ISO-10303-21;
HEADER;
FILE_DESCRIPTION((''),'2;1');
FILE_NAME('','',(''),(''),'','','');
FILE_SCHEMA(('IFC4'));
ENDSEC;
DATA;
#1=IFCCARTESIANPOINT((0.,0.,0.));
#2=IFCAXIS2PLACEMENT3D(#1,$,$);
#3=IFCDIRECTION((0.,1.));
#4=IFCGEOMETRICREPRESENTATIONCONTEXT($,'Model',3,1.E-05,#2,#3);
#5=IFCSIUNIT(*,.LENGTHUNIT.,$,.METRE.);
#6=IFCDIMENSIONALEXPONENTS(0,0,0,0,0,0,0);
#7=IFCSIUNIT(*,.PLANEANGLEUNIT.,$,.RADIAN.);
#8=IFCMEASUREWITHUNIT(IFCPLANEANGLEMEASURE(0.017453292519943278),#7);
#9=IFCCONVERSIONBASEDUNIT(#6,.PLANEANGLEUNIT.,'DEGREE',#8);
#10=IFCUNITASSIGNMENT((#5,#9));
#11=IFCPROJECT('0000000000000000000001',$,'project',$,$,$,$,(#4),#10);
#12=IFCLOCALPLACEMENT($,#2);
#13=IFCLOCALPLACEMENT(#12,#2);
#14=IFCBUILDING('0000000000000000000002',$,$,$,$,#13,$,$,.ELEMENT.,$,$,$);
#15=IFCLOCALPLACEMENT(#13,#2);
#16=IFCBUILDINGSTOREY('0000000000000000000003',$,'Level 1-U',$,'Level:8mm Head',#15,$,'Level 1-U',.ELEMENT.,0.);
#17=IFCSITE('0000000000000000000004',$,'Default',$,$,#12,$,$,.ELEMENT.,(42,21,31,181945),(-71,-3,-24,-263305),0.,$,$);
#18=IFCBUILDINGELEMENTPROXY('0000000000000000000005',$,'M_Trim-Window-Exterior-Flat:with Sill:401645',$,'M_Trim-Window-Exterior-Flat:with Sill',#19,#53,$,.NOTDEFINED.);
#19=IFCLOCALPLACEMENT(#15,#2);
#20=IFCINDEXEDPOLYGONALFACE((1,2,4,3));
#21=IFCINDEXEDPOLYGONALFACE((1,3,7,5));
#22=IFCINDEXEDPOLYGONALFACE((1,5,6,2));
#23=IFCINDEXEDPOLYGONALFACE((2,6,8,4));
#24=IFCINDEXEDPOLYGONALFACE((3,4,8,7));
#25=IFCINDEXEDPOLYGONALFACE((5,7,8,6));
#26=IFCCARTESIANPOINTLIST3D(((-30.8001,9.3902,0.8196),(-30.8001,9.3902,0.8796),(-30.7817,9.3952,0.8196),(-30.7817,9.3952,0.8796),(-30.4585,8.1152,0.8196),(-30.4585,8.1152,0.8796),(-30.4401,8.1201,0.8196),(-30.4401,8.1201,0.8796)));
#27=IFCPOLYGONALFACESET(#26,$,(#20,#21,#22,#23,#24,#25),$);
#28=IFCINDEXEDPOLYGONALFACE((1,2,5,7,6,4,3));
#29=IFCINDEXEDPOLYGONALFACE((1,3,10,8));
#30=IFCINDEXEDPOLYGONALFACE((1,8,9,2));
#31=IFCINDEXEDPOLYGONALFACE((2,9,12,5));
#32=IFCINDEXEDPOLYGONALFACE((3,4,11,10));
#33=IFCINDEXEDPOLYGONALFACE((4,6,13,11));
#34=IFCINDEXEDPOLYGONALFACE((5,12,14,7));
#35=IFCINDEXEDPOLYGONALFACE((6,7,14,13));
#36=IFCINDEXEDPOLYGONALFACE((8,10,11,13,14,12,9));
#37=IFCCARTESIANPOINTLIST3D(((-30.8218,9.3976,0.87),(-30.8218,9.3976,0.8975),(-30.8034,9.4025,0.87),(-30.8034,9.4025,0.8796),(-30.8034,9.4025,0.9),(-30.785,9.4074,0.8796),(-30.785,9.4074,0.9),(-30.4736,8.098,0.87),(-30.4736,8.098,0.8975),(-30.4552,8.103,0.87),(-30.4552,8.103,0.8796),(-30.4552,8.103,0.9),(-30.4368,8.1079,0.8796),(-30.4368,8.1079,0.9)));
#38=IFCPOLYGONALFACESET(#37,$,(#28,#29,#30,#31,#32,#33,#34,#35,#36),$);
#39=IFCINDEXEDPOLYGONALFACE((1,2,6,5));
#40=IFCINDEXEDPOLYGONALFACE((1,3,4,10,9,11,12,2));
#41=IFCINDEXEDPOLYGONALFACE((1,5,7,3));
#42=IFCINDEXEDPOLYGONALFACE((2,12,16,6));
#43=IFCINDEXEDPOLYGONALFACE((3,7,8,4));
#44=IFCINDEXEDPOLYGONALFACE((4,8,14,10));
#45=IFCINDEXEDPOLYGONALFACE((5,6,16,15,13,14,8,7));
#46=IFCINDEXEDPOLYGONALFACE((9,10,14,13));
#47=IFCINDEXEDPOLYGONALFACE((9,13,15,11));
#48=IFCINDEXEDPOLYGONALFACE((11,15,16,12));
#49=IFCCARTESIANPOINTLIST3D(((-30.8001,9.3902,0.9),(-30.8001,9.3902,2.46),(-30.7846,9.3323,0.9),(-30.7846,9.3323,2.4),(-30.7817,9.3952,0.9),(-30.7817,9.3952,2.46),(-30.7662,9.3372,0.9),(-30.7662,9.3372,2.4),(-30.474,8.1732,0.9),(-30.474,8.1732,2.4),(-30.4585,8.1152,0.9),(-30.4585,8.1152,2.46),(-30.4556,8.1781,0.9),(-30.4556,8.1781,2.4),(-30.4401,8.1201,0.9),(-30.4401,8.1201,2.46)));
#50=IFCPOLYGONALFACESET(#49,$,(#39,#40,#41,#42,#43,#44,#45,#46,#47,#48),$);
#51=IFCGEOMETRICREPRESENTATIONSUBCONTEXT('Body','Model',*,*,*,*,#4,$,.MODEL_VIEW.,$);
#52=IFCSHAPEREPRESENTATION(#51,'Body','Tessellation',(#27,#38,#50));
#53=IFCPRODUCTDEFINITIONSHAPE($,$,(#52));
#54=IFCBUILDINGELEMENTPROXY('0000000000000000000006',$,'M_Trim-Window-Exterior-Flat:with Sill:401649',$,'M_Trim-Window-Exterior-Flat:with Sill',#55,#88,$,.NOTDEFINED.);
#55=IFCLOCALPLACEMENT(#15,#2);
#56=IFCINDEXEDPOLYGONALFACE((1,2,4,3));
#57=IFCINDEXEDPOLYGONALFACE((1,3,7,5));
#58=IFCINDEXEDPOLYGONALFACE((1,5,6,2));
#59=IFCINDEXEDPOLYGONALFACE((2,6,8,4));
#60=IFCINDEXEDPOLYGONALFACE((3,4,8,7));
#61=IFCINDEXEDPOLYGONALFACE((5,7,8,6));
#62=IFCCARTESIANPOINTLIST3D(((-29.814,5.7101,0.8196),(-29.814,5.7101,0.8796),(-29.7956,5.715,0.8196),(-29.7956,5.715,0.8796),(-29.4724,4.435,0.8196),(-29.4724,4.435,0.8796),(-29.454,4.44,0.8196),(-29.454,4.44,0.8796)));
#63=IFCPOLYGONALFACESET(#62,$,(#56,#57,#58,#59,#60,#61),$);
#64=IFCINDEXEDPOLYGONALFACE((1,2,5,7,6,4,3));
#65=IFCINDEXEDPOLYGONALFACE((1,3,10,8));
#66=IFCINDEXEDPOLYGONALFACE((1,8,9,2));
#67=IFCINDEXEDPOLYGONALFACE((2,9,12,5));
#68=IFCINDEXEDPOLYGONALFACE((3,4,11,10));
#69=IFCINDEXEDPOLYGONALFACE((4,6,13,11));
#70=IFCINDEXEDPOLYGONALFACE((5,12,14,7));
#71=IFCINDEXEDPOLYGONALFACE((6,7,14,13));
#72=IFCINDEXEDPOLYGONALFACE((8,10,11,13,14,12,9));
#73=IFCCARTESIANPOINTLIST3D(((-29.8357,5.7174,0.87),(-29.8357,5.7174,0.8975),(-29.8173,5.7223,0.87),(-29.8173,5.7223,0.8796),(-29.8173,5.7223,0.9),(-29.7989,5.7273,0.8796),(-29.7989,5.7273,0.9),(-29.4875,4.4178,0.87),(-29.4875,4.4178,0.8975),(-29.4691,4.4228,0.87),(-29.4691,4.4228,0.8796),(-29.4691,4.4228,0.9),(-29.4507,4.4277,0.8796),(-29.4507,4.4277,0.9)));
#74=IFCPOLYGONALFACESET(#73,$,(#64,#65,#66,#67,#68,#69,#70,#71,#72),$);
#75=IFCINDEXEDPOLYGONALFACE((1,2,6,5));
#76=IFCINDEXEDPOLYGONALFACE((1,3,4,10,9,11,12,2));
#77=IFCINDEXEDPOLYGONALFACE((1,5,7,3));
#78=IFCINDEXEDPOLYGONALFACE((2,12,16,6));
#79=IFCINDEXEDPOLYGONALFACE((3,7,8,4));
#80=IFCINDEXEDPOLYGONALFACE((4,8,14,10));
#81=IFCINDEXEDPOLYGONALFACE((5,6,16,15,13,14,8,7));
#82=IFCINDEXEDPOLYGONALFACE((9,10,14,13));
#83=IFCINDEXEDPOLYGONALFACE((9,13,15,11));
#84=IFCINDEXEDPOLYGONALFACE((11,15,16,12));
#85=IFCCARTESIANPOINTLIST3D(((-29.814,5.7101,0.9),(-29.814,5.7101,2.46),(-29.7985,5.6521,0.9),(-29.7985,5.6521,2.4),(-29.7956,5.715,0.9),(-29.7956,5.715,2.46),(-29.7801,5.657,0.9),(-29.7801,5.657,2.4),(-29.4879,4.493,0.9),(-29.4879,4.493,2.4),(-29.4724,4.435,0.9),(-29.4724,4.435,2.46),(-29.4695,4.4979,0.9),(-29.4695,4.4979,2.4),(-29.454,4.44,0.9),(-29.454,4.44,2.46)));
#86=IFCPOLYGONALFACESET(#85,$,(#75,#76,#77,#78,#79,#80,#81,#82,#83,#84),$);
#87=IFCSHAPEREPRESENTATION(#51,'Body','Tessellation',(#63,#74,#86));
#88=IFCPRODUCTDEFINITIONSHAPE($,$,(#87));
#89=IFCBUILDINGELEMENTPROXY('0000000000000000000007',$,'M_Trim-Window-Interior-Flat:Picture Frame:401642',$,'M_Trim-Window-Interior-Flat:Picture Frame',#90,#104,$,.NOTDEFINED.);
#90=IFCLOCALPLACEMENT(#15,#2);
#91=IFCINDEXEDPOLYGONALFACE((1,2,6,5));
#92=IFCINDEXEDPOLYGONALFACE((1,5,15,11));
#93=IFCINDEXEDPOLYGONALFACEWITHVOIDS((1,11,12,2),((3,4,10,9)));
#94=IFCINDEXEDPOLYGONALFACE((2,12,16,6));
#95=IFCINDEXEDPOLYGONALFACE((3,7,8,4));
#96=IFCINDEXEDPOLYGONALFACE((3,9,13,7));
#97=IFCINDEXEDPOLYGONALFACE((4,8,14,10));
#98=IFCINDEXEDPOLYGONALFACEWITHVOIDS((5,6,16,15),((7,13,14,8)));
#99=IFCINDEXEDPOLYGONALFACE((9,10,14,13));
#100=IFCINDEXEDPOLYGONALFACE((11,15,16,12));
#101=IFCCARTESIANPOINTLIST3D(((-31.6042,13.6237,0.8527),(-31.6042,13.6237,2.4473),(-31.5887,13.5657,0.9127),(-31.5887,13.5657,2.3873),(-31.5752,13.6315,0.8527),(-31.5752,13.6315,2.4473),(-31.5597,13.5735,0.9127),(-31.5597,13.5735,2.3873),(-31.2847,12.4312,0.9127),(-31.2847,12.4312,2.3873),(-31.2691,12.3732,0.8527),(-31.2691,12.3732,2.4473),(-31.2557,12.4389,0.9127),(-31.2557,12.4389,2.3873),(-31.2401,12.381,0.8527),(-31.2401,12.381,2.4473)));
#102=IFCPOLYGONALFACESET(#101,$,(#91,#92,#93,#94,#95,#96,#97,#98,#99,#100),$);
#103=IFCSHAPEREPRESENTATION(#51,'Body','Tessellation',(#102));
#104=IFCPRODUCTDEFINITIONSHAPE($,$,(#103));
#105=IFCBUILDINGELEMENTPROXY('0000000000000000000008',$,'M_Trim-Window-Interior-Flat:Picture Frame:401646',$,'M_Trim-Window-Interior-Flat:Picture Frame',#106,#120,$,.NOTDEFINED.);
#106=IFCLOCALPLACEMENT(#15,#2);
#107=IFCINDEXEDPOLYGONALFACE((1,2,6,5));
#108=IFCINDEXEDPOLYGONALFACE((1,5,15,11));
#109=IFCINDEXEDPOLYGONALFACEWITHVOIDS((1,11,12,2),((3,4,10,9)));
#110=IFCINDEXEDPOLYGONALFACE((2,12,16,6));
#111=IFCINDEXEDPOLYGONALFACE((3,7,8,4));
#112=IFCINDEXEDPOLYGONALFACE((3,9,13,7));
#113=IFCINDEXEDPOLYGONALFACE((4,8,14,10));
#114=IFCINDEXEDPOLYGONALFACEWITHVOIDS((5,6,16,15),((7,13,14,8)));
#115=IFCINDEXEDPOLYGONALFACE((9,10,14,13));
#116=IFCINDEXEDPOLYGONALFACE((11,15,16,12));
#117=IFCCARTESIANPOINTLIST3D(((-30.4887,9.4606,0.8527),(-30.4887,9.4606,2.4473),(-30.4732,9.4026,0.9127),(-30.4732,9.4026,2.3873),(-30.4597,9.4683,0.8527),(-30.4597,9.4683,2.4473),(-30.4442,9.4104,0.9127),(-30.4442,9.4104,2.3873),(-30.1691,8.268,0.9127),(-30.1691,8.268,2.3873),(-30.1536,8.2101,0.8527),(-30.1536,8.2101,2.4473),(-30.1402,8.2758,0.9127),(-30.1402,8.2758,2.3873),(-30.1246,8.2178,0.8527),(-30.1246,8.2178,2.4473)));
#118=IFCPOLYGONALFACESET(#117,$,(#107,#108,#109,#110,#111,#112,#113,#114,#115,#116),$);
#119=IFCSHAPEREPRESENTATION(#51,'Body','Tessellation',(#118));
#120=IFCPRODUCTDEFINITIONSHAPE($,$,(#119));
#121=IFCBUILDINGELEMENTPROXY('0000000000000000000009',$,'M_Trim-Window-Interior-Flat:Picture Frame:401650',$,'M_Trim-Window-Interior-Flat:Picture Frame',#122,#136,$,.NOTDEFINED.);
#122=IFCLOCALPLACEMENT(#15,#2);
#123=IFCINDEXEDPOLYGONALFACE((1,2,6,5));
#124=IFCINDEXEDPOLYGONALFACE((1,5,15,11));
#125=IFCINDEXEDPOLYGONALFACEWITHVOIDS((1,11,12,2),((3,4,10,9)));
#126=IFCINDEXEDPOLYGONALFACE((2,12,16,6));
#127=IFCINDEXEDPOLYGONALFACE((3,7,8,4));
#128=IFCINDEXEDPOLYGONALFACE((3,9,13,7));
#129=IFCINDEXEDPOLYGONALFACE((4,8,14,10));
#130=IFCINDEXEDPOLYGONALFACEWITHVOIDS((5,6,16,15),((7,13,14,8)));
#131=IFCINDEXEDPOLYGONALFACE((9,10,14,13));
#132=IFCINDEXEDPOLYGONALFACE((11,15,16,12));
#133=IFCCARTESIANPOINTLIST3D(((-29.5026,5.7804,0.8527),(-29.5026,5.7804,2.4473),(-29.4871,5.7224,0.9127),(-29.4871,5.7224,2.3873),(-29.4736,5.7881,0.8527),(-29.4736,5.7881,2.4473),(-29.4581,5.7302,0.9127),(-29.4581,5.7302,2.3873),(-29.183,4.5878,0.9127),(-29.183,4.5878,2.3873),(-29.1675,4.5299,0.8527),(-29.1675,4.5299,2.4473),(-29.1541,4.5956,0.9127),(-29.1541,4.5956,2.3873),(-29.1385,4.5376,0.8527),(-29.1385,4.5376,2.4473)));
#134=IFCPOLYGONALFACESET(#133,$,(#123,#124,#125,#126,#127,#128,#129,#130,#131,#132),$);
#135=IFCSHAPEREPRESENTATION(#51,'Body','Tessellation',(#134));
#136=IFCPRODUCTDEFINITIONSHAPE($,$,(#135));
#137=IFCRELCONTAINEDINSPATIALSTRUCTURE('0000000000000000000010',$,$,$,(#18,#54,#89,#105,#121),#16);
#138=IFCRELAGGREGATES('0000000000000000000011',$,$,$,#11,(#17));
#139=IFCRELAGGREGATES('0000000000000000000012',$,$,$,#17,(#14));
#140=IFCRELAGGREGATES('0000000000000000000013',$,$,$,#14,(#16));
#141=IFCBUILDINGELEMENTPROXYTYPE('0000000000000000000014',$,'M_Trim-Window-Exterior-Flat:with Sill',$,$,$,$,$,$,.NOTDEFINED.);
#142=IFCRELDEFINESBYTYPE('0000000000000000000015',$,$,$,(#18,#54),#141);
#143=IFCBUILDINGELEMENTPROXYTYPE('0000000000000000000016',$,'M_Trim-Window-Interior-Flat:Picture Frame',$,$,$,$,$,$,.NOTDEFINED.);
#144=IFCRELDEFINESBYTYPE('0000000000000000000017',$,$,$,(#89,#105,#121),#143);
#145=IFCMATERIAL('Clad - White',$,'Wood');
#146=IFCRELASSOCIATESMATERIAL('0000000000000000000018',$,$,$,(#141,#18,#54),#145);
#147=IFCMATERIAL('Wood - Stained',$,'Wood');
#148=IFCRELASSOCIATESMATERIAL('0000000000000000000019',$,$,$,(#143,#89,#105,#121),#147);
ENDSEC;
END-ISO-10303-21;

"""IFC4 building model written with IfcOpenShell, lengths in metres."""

from ifc_helpers import new_model, entity, si_unit, converted_unit, direction, frame, origin, place, context, subcontext, project, spatial, indexed_curve, outline, extrude, source, transform, mapped, material, type_object, type_shapes, element, save


model = new_model("IFC4")

# Units and contexts
model_context = context("Model", 3, precision=1e-05, world=origin(), true_north=direction((0.0, 1.0)))
body_context = subcontext(model_context, "Body", "Model", "MODEL_VIEW")
ifc_project = project(units=[si_unit("LENGTHUNIT", "METRE"), converted_unit("PLANEANGLEUNIT", "DEGREE", entity("IfcPlaneAngleMeasure", 0.017453292519943278), si_unit("PLANEANGLEUNIT", "RADIAN"), dimensions=[0, 0, 0, 0, 0, 0, 0])], contexts=[model_context])

# Site, building, storey
site_placement = place(None, origin())
site = spatial("IfcSite", under=ifc_project, at=site_placement, Name="Default", CompositionType="ELEMENT", RefLatitude=(42, 21, 31, 181945), RefLongitude=(-71, -3, -24, -263305), RefElevation=0.0)
building_placement = place(site_placement, origin())
building = spatial("IfcBuilding", under=site, at=building_placement, CompositionType="ELEMENT")
storey_placement = place(building_placement, origin())
storey = spatial("IfcBuildingStorey", under=building, at=storey_placement, Name="Level 1-U", ObjectType="Level:8mm Head", LongName="Level 1-U", CompositionType="ELEMENT", Elevation=0.0)

# Building element proxies
ifc_material_1 = material(Name="Clad - White", Category="Wood")
ifc_material_2 = material(Name="Wood - Stained", Category="Wood")
building_element_proxy_type_1 = type_object("IfcBuildingElementProxyType", Name="M_Trim-Window-Exterior-Flat:with Sill", PredefinedType="NOTDEFINED", material=ifc_material_1)
shared_shape_1 = source(origin(), body_context, "Body", "SweptSolid", [
    extrude(outline(indexed_curve([(-0.66, -0.03), (0.66, -0.03), (0.66, 0.03), (-0.66, 0.03), (-0.66, -0.03)], self_intersect=False)), frame((0.0, -1.5504, 0.0), z_axis=(0.0, 0.0, 1.0), x_axis=(-1.0, 0.0, 0.0)), (0.0, 0.0, 1.0), 0.019),
    extrude(outline(indexed_curve([(-0.019, -0.0152), (0.0, -0.0152), (0.0, -0.0057), (0.019, -0.0057), (0.019, 0.0148), (0.0, 0.0148), (-0.019, 0.0123), (-0.019, -0.0152)], self_intersect=False)), frame((-0.6727, -1.5148, 0.019), z_axis=(1.0, 0.0, 0.0), x_axis=(0.0, 0.0, -1.0)), (0.0, 0.0, 1.0), 1.3454),
    extrude(outline(indexed_curve([(-0.795, -0.66), (0.765, -0.66), (0.765, -0.6), (-0.735, -0.6), (-0.735, 0.6), (0.765, 0.6), (0.765, 0.66), (-0.795, 0.66), (-0.795, -0.66)], self_intersect=False)), frame((0.0, -0.735, 0.0), z_axis=(0.0, 0.0, 1.0), x_axis=(0.0, -1.0, 0.0)), (0.0, 0.0, 1.0), 0.019),
])
type_shapes(building_element_proxy_type_1, [shared_shape_1])
for number, where, z_axis, x_axis, name in (
    (1, (-30.6109, 8.7577, 2.4), (-0.965926, -0.258819, 0.0), (0.258819, -0.965926, 0.0), "M_Trim-Window-Exterior-Flat:with Sill:401645"),
    (2, (-29.6248, 5.0775, 2.4), (-0.965926, -0.258819, 0.0), (0.258819, -0.965926, 0.0), "M_Trim-Window-Exterior-Flat:with Sill:401649"),
):
    element("IfcBuildingElementProxy", number, at=place(storey_placement, frame(where, z_axis=z_axis, x_axis=x_axis)), inside=storey, type_object=building_element_proxy_type_1, material=ifc_material_1, Name=name, ObjectType="M_Trim-Window-Exterior-Flat:with Sill", PredefinedType="NOTDEFINED", context=body_context, shape_type="MappedRepresentation", body=[
        mapped(shared_shape_1, transform((0.0, 0.0, 0.0), scale=1.0)),
    ])
building_element_proxy_type_2 = type_object("IfcBuildingElementProxyType", Name="M_Trim-Window-Interior-Flat:Picture Frame", PredefinedType="NOTDEFINED", material=ifc_material_2)
shared_shape_2 = source(origin(), body_context, "Body", "SweptSolid", [
    extrude(outline(indexed_curve([(-0.6473, -0.7973), (0.6473, -0.7973), (0.6473, 0.7973), (-0.6473, 0.7973), (-0.6473, -0.7973)], self_intersect=False), holes=[indexed_curve([(-0.5873, -0.7373), (-0.5873, 0.7373), (0.5873, 0.7373), (0.5873, -0.7373), (-0.5873, -0.7373)], self_intersect=False)]), frame((0.0, -0.75, 0.0), z_axis=(0.0, 0.0, 1.0), x_axis=(-1.0, 0.0, 0.0)), (0.0, 0.0, 1.0), 0.03),
])
type_shapes(building_element_proxy_type_2, [shared_shape_2])
for number, where, z_axis, x_axis, name in (
    (3, (-31.4367, 12.9984, 2.4), (0.965926, 0.258819, 0.0), (-0.258819, 0.965926, 0.0), "M_Trim-Window-Interior-Flat:Picture Frame:401642"),
    (4, (-30.3211, 8.8353, 2.4), (0.965926, 0.258819, 0.0), (-0.258819, 0.965926, 0.0), "M_Trim-Window-Interior-Flat:Picture Frame:401646"),
    (5, (-29.335, 5.1551, 2.4), (0.965926, 0.258819, 0.0), (-0.258819, 0.965926, 0.0), "M_Trim-Window-Interior-Flat:Picture Frame:401650"),
):
    element("IfcBuildingElementProxy", number, at=place(storey_placement, frame(where, z_axis=z_axis, x_axis=x_axis)), inside=storey, type_object=building_element_proxy_type_2, material=ifc_material_2, Name=name, ObjectType="M_Trim-Window-Interior-Flat:Picture Frame", PredefinedType="NOTDEFINED", context=body_context, shape_type="MappedRepresentation", body=[
        mapped(shared_shape_2, transform((0.0, 0.0, 0.0), scale=1.0)),
    ])

save(model, "model.ifc")
